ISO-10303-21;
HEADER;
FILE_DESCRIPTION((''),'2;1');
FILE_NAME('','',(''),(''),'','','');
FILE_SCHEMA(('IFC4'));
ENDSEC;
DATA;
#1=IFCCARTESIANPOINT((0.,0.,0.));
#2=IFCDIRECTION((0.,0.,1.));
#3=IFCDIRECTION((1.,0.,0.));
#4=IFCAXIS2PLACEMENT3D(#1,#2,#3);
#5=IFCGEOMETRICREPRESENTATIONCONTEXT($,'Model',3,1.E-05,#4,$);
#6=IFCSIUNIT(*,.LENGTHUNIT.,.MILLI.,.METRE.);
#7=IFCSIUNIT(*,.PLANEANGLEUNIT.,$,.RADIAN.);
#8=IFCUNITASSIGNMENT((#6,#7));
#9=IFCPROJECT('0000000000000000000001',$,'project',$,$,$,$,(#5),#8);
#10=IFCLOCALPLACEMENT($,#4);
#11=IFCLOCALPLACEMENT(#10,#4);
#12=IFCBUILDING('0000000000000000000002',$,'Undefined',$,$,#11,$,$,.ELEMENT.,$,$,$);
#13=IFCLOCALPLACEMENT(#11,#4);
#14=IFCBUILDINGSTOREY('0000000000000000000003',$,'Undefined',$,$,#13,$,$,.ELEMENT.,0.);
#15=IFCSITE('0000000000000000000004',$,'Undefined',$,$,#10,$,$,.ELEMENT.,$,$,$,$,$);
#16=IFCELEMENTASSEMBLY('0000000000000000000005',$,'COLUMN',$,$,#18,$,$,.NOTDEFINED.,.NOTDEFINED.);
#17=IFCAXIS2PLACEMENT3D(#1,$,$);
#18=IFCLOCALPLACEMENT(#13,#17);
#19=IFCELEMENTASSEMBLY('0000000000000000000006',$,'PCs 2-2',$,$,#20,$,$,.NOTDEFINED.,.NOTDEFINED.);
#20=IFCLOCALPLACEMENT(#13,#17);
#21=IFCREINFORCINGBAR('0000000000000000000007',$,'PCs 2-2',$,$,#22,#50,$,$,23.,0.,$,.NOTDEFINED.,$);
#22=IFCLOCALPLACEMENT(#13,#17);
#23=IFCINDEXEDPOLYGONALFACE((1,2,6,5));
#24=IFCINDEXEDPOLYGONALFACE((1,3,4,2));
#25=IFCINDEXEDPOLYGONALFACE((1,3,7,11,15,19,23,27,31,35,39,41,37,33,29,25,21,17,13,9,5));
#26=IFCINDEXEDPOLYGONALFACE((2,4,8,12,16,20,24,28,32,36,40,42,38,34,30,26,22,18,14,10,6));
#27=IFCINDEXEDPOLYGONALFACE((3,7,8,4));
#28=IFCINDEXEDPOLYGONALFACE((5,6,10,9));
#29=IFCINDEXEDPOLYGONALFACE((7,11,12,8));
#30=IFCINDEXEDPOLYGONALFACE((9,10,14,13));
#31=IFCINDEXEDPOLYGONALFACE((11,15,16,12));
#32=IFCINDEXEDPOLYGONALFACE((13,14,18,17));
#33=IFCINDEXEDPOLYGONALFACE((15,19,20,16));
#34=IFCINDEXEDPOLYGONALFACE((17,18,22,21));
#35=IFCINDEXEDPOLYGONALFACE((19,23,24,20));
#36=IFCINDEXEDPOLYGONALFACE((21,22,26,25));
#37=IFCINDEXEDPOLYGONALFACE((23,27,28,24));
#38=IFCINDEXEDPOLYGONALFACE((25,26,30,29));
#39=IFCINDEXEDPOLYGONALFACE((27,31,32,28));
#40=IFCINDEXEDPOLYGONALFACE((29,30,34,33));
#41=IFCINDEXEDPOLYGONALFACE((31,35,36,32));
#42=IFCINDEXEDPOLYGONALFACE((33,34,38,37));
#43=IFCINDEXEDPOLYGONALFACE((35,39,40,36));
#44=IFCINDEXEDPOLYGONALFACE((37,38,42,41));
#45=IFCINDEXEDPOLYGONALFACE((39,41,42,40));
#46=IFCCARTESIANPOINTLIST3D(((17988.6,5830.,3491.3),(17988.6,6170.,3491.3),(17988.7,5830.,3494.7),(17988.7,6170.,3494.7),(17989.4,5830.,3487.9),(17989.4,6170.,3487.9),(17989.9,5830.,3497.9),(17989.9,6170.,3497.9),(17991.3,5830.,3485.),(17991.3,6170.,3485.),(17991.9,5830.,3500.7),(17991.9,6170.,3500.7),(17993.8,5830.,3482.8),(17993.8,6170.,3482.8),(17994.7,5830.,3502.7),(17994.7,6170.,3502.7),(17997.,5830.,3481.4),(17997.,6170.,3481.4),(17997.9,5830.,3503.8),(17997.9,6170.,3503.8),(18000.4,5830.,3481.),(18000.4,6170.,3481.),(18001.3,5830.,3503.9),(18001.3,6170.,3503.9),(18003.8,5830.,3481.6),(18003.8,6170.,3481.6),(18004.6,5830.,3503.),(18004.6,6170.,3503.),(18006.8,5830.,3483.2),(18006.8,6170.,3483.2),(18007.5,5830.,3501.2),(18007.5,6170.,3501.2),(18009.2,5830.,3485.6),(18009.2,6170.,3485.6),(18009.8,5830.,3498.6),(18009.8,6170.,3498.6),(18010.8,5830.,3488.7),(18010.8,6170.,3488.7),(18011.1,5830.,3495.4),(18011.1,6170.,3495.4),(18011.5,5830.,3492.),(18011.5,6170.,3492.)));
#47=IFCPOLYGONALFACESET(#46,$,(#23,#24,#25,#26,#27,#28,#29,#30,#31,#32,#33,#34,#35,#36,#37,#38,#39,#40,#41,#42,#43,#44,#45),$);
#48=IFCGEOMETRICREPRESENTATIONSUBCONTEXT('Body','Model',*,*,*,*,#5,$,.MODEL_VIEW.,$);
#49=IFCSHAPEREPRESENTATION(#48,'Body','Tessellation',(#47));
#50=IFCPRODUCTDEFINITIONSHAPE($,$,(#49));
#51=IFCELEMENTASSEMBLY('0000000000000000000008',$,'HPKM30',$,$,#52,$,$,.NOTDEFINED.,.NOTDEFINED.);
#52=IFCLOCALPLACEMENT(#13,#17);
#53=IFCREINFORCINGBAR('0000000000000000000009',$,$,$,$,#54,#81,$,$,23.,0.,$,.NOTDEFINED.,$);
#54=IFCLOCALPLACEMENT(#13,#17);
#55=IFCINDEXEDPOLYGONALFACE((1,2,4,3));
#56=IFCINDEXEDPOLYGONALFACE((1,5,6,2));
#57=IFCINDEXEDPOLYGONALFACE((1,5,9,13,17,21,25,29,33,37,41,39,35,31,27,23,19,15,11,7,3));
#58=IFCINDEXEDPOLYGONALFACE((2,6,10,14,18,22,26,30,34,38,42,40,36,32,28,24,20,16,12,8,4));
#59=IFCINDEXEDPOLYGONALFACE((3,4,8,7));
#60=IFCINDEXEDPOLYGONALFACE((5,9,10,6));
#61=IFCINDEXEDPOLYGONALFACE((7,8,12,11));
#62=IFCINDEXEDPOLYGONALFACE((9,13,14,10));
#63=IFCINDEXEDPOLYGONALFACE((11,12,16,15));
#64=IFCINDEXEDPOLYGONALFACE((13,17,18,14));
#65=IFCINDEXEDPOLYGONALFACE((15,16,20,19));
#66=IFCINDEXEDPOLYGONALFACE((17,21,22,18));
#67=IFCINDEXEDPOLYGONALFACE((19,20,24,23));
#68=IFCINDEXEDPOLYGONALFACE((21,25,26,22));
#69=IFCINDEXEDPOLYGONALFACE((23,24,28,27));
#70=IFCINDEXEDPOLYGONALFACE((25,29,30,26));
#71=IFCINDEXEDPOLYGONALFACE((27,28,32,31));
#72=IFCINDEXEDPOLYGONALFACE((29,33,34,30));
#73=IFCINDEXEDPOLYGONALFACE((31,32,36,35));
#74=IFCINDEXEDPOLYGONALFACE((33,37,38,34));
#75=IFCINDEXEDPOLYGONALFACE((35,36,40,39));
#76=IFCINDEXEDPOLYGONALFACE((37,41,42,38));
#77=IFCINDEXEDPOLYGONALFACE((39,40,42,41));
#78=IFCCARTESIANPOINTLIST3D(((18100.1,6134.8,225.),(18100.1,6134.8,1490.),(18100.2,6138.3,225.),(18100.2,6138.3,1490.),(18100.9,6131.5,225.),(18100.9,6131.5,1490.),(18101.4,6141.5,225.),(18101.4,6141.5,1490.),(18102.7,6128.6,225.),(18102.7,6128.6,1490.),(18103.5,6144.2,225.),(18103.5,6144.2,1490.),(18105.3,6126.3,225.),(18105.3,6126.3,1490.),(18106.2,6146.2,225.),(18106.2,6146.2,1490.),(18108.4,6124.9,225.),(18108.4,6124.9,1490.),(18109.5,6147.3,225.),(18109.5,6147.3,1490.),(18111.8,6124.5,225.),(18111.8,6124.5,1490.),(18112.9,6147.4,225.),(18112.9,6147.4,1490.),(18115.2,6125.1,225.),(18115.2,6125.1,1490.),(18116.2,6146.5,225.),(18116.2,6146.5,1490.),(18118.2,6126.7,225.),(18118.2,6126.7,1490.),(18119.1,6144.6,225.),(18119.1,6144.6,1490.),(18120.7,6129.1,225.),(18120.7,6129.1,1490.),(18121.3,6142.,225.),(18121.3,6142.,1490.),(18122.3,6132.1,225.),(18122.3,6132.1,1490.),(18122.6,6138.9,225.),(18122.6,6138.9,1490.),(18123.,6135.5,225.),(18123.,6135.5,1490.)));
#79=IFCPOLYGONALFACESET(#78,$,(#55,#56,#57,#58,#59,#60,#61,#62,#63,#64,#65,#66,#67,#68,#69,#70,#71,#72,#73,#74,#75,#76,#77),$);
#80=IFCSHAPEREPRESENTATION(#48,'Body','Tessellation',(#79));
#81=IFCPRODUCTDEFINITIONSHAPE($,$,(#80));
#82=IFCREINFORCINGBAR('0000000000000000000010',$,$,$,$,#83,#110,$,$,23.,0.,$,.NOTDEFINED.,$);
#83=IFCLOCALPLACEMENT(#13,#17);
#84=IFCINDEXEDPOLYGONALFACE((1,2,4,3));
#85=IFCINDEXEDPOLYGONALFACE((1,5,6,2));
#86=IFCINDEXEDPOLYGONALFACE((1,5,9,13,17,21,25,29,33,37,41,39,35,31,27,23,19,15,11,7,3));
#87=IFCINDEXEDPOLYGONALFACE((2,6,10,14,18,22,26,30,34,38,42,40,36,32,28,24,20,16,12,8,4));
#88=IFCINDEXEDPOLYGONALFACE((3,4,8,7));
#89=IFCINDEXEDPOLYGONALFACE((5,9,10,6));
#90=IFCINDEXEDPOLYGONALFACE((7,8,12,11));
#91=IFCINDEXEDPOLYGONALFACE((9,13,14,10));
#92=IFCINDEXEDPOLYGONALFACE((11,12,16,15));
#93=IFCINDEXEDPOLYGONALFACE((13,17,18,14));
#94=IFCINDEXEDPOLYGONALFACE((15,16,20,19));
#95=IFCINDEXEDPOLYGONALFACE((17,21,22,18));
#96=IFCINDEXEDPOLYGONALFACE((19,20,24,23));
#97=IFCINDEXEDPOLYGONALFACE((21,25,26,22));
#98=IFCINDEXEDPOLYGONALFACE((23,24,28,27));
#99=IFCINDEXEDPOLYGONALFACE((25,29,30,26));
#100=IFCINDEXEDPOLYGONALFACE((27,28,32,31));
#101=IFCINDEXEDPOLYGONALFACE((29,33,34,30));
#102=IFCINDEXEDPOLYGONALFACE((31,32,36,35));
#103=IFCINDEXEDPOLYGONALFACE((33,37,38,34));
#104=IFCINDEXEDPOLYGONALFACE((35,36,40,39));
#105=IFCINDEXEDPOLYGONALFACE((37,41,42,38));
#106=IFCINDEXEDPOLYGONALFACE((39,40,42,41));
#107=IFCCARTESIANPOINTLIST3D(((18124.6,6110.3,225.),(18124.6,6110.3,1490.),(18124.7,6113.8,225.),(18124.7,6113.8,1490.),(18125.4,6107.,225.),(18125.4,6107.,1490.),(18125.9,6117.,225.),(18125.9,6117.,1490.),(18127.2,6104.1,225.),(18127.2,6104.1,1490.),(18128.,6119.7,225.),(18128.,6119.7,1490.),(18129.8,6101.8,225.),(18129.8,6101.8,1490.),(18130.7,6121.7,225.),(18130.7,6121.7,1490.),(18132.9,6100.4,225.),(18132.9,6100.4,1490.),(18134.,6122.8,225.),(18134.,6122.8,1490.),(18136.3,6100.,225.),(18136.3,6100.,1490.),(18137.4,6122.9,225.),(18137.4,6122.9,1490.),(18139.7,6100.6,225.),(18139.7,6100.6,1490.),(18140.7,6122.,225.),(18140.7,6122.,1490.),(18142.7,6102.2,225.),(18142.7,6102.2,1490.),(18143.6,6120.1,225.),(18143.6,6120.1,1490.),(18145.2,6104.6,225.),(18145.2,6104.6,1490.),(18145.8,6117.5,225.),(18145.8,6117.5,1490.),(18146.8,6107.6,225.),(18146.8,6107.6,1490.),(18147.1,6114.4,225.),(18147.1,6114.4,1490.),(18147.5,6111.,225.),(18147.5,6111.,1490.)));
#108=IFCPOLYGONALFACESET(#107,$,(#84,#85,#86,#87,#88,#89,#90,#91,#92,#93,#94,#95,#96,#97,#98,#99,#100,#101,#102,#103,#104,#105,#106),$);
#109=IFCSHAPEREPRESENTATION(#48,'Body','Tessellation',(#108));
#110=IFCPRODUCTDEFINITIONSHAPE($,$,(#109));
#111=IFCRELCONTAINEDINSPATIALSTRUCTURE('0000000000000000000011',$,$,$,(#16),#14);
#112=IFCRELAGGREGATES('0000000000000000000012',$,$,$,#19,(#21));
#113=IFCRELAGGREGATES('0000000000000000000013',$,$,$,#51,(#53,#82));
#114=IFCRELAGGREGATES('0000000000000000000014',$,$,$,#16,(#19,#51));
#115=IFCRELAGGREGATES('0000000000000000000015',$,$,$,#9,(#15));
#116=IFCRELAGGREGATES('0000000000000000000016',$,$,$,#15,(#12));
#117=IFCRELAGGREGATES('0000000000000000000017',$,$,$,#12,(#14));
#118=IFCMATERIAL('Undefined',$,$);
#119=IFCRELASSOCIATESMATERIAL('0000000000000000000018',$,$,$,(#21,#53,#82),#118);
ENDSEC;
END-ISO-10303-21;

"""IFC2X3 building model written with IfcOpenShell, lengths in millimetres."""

from ifc_helpers import new_model, entity, si_unit, frame, origin_with_axes, place, context, subcontext, project, spatial, source, transform, mapped, material, element, aggregate, save


model = new_model("IFC2X3")

# Units and contexts
model_context = context("Model", 3, precision=1e-05, world=origin_with_axes())
body_context = subcontext(model_context, "Body", "Model", "MODEL_VIEW")
ifc_project = project(units=[si_unit("LENGTHUNIT", "METRE", prefix="MILLI"), si_unit("PLANEANGLEUNIT", "RADIAN")], contexts=[model_context])

# Site, building, storey
site_placement = place(None, origin_with_axes())
site = spatial("IfcSite", under=ifc_project, at=site_placement, Name="Undefined", CompositionType="ELEMENT")
building_placement = place(site_placement, origin_with_axes())
building = spatial("IfcBuilding", under=site, at=building_placement, Name="Undefined", CompositionType="ELEMENT")
storey_placement = place(building_placement, origin_with_axes())
storey = spatial("IfcBuildingStorey", under=building, at=storey_placement, Name="Undefined", CompositionType="ELEMENT", Elevation=0.0)

# Element assemblies
assembly_1_placement = place(storey_placement, origin_with_axes())
assembly_1 = element("IfcElementAssembly", 1, at=assembly_1_placement, inside=storey, Name="COLUMN", AssemblyPlace="NOTDEFINED", PredefinedType="NOTDEFINED")
assembly_2_placement = place(assembly_1_placement, origin_with_axes())
assembly_2 = element("IfcElementAssembly", 2, at=assembly_2_placement, Name="PCs 2-2", AssemblyPlace="NOTDEFINED", PredefinedType="NOTDEFINED")

# Reinforcing bar
ifc_material_1 = material(Name="Undefined")
shared_shape_1 = source(origin_with_axes(), body_context, "Body", "AdvancedSweptSolid", [
    entity("IfcSweptDiskSolid", entity("IfcTrimmedCurve", entity("IfcLine", entity("IfcCartesianPoint", [0.0, 0.0, 0.0]), entity("IfcVector", entity("IfcDirection", [1.0, 0.0, 0.0]), 1.0)), [entity("IfcParameterValue", 0.0)], [entity("IfcParameterValue", 340.0)], True, "PARAMETER"), 11.5, None, 0.0, 340.0),
])
reinforcing_bar_1_placement = place(assembly_2_placement, frame((18000.0, 5830.0, 3492.5), z_axis=(-0.182177, 0.0, 0.983266), x_axis=(0.0, 1.0, 0.0)))
reinforcing_bar_1 = element("IfcReinforcingBar", 3, at=reinforcing_bar_1_placement, material=ifc_material_1, Name="PCs 2-2", BarRole="NOTDEFINED", CrossSectionArea=0.0, NominalDiameter=23.0, context=body_context, shape_type="MappedRepresentation", body=[
    mapped(shared_shape_1, transform((0.0, 0.0, 0.0))),
])
aggregate(assembly_2, [reinforcing_bar_1])

# Element assembly, reinforcing bars
assembly_3_placement = place(assembly_1_placement, origin_with_axes())
assembly_3 = element("IfcElementAssembly", 4, at=assembly_3_placement, Name="HPKM30", AssemblyPlace="NOTDEFINED", PredefinedType="NOTDEFINED")
shared_shape_2 = source(origin_with_axes(), body_context, "Body", "AdvancedSweptSolid", [
    entity("IfcSweptDiskSolid", entity("IfcTrimmedCurve", entity("IfcLine", entity("IfcCartesianPoint", [0.0, 0.0, 0.0]), entity("IfcVector", entity("IfcDirection", [1.0, 0.0, 0.0]), 1.0)), [entity("IfcParameterValue", 0.0)], [entity("IfcParameterValue", 1265.0)], True, "PARAMETER"), 11.5, None, 0.0, 1265.0),
])
reinforcing_bar_2_placement = place(assembly_3_placement, frame((18111.5, 6136.0, 225.0), z_axis=(0.320611, -0.947211, 0.0), x_axis=(0.0, 0.0, 1.0)))
reinforcing_bar_2 = element("IfcReinforcingBar", 5, at=reinforcing_bar_2_placement, material=ifc_material_1, BarRole="NOTDEFINED", CrossSectionArea=0.0, NominalDiameter=23.0, context=body_context, shape_type="MappedRepresentation", body=[
    mapped(shared_shape_2, transform((0.0, 0.0, 0.0))),
])
shared_shape_3 = source(origin_with_axes(), body_context, "Body", "AdvancedSweptSolid", [
    entity("IfcSweptDiskSolid", entity("IfcTrimmedCurve", entity("IfcLine", entity("IfcCartesianPoint", [0.0, 0.0, 0.0]), entity("IfcVector", entity("IfcDirection", [1.0, 0.0, 0.0]), 1.0)), [entity("IfcParameterValue", 0.0)], [entity("IfcParameterValue", 1265.0)], True, "PARAMETER"), 11.5, None, 0.0, 1265.0),
])
reinforcing_bar_3_placement = place(assembly_3_placement, frame((18136.0, 6111.5, 225.0), z_axis=(0.320611, -0.947211, 0.0), x_axis=(0.0, 0.0, 1.0)))
reinforcing_bar_3 = element("IfcReinforcingBar", 6, at=reinforcing_bar_3_placement, material=ifc_material_1, BarRole="NOTDEFINED", CrossSectionArea=0.0, NominalDiameter=23.0, context=body_context, shape_type="MappedRepresentation", body=[
    mapped(shared_shape_3, transform((0.0, 0.0, 0.0))),
])
aggregate(assembly_3, [reinforcing_bar_2, reinforcing_bar_3])

aggregate(assembly_1, [assembly_2, assembly_3])

save(model, "model.ifc")
